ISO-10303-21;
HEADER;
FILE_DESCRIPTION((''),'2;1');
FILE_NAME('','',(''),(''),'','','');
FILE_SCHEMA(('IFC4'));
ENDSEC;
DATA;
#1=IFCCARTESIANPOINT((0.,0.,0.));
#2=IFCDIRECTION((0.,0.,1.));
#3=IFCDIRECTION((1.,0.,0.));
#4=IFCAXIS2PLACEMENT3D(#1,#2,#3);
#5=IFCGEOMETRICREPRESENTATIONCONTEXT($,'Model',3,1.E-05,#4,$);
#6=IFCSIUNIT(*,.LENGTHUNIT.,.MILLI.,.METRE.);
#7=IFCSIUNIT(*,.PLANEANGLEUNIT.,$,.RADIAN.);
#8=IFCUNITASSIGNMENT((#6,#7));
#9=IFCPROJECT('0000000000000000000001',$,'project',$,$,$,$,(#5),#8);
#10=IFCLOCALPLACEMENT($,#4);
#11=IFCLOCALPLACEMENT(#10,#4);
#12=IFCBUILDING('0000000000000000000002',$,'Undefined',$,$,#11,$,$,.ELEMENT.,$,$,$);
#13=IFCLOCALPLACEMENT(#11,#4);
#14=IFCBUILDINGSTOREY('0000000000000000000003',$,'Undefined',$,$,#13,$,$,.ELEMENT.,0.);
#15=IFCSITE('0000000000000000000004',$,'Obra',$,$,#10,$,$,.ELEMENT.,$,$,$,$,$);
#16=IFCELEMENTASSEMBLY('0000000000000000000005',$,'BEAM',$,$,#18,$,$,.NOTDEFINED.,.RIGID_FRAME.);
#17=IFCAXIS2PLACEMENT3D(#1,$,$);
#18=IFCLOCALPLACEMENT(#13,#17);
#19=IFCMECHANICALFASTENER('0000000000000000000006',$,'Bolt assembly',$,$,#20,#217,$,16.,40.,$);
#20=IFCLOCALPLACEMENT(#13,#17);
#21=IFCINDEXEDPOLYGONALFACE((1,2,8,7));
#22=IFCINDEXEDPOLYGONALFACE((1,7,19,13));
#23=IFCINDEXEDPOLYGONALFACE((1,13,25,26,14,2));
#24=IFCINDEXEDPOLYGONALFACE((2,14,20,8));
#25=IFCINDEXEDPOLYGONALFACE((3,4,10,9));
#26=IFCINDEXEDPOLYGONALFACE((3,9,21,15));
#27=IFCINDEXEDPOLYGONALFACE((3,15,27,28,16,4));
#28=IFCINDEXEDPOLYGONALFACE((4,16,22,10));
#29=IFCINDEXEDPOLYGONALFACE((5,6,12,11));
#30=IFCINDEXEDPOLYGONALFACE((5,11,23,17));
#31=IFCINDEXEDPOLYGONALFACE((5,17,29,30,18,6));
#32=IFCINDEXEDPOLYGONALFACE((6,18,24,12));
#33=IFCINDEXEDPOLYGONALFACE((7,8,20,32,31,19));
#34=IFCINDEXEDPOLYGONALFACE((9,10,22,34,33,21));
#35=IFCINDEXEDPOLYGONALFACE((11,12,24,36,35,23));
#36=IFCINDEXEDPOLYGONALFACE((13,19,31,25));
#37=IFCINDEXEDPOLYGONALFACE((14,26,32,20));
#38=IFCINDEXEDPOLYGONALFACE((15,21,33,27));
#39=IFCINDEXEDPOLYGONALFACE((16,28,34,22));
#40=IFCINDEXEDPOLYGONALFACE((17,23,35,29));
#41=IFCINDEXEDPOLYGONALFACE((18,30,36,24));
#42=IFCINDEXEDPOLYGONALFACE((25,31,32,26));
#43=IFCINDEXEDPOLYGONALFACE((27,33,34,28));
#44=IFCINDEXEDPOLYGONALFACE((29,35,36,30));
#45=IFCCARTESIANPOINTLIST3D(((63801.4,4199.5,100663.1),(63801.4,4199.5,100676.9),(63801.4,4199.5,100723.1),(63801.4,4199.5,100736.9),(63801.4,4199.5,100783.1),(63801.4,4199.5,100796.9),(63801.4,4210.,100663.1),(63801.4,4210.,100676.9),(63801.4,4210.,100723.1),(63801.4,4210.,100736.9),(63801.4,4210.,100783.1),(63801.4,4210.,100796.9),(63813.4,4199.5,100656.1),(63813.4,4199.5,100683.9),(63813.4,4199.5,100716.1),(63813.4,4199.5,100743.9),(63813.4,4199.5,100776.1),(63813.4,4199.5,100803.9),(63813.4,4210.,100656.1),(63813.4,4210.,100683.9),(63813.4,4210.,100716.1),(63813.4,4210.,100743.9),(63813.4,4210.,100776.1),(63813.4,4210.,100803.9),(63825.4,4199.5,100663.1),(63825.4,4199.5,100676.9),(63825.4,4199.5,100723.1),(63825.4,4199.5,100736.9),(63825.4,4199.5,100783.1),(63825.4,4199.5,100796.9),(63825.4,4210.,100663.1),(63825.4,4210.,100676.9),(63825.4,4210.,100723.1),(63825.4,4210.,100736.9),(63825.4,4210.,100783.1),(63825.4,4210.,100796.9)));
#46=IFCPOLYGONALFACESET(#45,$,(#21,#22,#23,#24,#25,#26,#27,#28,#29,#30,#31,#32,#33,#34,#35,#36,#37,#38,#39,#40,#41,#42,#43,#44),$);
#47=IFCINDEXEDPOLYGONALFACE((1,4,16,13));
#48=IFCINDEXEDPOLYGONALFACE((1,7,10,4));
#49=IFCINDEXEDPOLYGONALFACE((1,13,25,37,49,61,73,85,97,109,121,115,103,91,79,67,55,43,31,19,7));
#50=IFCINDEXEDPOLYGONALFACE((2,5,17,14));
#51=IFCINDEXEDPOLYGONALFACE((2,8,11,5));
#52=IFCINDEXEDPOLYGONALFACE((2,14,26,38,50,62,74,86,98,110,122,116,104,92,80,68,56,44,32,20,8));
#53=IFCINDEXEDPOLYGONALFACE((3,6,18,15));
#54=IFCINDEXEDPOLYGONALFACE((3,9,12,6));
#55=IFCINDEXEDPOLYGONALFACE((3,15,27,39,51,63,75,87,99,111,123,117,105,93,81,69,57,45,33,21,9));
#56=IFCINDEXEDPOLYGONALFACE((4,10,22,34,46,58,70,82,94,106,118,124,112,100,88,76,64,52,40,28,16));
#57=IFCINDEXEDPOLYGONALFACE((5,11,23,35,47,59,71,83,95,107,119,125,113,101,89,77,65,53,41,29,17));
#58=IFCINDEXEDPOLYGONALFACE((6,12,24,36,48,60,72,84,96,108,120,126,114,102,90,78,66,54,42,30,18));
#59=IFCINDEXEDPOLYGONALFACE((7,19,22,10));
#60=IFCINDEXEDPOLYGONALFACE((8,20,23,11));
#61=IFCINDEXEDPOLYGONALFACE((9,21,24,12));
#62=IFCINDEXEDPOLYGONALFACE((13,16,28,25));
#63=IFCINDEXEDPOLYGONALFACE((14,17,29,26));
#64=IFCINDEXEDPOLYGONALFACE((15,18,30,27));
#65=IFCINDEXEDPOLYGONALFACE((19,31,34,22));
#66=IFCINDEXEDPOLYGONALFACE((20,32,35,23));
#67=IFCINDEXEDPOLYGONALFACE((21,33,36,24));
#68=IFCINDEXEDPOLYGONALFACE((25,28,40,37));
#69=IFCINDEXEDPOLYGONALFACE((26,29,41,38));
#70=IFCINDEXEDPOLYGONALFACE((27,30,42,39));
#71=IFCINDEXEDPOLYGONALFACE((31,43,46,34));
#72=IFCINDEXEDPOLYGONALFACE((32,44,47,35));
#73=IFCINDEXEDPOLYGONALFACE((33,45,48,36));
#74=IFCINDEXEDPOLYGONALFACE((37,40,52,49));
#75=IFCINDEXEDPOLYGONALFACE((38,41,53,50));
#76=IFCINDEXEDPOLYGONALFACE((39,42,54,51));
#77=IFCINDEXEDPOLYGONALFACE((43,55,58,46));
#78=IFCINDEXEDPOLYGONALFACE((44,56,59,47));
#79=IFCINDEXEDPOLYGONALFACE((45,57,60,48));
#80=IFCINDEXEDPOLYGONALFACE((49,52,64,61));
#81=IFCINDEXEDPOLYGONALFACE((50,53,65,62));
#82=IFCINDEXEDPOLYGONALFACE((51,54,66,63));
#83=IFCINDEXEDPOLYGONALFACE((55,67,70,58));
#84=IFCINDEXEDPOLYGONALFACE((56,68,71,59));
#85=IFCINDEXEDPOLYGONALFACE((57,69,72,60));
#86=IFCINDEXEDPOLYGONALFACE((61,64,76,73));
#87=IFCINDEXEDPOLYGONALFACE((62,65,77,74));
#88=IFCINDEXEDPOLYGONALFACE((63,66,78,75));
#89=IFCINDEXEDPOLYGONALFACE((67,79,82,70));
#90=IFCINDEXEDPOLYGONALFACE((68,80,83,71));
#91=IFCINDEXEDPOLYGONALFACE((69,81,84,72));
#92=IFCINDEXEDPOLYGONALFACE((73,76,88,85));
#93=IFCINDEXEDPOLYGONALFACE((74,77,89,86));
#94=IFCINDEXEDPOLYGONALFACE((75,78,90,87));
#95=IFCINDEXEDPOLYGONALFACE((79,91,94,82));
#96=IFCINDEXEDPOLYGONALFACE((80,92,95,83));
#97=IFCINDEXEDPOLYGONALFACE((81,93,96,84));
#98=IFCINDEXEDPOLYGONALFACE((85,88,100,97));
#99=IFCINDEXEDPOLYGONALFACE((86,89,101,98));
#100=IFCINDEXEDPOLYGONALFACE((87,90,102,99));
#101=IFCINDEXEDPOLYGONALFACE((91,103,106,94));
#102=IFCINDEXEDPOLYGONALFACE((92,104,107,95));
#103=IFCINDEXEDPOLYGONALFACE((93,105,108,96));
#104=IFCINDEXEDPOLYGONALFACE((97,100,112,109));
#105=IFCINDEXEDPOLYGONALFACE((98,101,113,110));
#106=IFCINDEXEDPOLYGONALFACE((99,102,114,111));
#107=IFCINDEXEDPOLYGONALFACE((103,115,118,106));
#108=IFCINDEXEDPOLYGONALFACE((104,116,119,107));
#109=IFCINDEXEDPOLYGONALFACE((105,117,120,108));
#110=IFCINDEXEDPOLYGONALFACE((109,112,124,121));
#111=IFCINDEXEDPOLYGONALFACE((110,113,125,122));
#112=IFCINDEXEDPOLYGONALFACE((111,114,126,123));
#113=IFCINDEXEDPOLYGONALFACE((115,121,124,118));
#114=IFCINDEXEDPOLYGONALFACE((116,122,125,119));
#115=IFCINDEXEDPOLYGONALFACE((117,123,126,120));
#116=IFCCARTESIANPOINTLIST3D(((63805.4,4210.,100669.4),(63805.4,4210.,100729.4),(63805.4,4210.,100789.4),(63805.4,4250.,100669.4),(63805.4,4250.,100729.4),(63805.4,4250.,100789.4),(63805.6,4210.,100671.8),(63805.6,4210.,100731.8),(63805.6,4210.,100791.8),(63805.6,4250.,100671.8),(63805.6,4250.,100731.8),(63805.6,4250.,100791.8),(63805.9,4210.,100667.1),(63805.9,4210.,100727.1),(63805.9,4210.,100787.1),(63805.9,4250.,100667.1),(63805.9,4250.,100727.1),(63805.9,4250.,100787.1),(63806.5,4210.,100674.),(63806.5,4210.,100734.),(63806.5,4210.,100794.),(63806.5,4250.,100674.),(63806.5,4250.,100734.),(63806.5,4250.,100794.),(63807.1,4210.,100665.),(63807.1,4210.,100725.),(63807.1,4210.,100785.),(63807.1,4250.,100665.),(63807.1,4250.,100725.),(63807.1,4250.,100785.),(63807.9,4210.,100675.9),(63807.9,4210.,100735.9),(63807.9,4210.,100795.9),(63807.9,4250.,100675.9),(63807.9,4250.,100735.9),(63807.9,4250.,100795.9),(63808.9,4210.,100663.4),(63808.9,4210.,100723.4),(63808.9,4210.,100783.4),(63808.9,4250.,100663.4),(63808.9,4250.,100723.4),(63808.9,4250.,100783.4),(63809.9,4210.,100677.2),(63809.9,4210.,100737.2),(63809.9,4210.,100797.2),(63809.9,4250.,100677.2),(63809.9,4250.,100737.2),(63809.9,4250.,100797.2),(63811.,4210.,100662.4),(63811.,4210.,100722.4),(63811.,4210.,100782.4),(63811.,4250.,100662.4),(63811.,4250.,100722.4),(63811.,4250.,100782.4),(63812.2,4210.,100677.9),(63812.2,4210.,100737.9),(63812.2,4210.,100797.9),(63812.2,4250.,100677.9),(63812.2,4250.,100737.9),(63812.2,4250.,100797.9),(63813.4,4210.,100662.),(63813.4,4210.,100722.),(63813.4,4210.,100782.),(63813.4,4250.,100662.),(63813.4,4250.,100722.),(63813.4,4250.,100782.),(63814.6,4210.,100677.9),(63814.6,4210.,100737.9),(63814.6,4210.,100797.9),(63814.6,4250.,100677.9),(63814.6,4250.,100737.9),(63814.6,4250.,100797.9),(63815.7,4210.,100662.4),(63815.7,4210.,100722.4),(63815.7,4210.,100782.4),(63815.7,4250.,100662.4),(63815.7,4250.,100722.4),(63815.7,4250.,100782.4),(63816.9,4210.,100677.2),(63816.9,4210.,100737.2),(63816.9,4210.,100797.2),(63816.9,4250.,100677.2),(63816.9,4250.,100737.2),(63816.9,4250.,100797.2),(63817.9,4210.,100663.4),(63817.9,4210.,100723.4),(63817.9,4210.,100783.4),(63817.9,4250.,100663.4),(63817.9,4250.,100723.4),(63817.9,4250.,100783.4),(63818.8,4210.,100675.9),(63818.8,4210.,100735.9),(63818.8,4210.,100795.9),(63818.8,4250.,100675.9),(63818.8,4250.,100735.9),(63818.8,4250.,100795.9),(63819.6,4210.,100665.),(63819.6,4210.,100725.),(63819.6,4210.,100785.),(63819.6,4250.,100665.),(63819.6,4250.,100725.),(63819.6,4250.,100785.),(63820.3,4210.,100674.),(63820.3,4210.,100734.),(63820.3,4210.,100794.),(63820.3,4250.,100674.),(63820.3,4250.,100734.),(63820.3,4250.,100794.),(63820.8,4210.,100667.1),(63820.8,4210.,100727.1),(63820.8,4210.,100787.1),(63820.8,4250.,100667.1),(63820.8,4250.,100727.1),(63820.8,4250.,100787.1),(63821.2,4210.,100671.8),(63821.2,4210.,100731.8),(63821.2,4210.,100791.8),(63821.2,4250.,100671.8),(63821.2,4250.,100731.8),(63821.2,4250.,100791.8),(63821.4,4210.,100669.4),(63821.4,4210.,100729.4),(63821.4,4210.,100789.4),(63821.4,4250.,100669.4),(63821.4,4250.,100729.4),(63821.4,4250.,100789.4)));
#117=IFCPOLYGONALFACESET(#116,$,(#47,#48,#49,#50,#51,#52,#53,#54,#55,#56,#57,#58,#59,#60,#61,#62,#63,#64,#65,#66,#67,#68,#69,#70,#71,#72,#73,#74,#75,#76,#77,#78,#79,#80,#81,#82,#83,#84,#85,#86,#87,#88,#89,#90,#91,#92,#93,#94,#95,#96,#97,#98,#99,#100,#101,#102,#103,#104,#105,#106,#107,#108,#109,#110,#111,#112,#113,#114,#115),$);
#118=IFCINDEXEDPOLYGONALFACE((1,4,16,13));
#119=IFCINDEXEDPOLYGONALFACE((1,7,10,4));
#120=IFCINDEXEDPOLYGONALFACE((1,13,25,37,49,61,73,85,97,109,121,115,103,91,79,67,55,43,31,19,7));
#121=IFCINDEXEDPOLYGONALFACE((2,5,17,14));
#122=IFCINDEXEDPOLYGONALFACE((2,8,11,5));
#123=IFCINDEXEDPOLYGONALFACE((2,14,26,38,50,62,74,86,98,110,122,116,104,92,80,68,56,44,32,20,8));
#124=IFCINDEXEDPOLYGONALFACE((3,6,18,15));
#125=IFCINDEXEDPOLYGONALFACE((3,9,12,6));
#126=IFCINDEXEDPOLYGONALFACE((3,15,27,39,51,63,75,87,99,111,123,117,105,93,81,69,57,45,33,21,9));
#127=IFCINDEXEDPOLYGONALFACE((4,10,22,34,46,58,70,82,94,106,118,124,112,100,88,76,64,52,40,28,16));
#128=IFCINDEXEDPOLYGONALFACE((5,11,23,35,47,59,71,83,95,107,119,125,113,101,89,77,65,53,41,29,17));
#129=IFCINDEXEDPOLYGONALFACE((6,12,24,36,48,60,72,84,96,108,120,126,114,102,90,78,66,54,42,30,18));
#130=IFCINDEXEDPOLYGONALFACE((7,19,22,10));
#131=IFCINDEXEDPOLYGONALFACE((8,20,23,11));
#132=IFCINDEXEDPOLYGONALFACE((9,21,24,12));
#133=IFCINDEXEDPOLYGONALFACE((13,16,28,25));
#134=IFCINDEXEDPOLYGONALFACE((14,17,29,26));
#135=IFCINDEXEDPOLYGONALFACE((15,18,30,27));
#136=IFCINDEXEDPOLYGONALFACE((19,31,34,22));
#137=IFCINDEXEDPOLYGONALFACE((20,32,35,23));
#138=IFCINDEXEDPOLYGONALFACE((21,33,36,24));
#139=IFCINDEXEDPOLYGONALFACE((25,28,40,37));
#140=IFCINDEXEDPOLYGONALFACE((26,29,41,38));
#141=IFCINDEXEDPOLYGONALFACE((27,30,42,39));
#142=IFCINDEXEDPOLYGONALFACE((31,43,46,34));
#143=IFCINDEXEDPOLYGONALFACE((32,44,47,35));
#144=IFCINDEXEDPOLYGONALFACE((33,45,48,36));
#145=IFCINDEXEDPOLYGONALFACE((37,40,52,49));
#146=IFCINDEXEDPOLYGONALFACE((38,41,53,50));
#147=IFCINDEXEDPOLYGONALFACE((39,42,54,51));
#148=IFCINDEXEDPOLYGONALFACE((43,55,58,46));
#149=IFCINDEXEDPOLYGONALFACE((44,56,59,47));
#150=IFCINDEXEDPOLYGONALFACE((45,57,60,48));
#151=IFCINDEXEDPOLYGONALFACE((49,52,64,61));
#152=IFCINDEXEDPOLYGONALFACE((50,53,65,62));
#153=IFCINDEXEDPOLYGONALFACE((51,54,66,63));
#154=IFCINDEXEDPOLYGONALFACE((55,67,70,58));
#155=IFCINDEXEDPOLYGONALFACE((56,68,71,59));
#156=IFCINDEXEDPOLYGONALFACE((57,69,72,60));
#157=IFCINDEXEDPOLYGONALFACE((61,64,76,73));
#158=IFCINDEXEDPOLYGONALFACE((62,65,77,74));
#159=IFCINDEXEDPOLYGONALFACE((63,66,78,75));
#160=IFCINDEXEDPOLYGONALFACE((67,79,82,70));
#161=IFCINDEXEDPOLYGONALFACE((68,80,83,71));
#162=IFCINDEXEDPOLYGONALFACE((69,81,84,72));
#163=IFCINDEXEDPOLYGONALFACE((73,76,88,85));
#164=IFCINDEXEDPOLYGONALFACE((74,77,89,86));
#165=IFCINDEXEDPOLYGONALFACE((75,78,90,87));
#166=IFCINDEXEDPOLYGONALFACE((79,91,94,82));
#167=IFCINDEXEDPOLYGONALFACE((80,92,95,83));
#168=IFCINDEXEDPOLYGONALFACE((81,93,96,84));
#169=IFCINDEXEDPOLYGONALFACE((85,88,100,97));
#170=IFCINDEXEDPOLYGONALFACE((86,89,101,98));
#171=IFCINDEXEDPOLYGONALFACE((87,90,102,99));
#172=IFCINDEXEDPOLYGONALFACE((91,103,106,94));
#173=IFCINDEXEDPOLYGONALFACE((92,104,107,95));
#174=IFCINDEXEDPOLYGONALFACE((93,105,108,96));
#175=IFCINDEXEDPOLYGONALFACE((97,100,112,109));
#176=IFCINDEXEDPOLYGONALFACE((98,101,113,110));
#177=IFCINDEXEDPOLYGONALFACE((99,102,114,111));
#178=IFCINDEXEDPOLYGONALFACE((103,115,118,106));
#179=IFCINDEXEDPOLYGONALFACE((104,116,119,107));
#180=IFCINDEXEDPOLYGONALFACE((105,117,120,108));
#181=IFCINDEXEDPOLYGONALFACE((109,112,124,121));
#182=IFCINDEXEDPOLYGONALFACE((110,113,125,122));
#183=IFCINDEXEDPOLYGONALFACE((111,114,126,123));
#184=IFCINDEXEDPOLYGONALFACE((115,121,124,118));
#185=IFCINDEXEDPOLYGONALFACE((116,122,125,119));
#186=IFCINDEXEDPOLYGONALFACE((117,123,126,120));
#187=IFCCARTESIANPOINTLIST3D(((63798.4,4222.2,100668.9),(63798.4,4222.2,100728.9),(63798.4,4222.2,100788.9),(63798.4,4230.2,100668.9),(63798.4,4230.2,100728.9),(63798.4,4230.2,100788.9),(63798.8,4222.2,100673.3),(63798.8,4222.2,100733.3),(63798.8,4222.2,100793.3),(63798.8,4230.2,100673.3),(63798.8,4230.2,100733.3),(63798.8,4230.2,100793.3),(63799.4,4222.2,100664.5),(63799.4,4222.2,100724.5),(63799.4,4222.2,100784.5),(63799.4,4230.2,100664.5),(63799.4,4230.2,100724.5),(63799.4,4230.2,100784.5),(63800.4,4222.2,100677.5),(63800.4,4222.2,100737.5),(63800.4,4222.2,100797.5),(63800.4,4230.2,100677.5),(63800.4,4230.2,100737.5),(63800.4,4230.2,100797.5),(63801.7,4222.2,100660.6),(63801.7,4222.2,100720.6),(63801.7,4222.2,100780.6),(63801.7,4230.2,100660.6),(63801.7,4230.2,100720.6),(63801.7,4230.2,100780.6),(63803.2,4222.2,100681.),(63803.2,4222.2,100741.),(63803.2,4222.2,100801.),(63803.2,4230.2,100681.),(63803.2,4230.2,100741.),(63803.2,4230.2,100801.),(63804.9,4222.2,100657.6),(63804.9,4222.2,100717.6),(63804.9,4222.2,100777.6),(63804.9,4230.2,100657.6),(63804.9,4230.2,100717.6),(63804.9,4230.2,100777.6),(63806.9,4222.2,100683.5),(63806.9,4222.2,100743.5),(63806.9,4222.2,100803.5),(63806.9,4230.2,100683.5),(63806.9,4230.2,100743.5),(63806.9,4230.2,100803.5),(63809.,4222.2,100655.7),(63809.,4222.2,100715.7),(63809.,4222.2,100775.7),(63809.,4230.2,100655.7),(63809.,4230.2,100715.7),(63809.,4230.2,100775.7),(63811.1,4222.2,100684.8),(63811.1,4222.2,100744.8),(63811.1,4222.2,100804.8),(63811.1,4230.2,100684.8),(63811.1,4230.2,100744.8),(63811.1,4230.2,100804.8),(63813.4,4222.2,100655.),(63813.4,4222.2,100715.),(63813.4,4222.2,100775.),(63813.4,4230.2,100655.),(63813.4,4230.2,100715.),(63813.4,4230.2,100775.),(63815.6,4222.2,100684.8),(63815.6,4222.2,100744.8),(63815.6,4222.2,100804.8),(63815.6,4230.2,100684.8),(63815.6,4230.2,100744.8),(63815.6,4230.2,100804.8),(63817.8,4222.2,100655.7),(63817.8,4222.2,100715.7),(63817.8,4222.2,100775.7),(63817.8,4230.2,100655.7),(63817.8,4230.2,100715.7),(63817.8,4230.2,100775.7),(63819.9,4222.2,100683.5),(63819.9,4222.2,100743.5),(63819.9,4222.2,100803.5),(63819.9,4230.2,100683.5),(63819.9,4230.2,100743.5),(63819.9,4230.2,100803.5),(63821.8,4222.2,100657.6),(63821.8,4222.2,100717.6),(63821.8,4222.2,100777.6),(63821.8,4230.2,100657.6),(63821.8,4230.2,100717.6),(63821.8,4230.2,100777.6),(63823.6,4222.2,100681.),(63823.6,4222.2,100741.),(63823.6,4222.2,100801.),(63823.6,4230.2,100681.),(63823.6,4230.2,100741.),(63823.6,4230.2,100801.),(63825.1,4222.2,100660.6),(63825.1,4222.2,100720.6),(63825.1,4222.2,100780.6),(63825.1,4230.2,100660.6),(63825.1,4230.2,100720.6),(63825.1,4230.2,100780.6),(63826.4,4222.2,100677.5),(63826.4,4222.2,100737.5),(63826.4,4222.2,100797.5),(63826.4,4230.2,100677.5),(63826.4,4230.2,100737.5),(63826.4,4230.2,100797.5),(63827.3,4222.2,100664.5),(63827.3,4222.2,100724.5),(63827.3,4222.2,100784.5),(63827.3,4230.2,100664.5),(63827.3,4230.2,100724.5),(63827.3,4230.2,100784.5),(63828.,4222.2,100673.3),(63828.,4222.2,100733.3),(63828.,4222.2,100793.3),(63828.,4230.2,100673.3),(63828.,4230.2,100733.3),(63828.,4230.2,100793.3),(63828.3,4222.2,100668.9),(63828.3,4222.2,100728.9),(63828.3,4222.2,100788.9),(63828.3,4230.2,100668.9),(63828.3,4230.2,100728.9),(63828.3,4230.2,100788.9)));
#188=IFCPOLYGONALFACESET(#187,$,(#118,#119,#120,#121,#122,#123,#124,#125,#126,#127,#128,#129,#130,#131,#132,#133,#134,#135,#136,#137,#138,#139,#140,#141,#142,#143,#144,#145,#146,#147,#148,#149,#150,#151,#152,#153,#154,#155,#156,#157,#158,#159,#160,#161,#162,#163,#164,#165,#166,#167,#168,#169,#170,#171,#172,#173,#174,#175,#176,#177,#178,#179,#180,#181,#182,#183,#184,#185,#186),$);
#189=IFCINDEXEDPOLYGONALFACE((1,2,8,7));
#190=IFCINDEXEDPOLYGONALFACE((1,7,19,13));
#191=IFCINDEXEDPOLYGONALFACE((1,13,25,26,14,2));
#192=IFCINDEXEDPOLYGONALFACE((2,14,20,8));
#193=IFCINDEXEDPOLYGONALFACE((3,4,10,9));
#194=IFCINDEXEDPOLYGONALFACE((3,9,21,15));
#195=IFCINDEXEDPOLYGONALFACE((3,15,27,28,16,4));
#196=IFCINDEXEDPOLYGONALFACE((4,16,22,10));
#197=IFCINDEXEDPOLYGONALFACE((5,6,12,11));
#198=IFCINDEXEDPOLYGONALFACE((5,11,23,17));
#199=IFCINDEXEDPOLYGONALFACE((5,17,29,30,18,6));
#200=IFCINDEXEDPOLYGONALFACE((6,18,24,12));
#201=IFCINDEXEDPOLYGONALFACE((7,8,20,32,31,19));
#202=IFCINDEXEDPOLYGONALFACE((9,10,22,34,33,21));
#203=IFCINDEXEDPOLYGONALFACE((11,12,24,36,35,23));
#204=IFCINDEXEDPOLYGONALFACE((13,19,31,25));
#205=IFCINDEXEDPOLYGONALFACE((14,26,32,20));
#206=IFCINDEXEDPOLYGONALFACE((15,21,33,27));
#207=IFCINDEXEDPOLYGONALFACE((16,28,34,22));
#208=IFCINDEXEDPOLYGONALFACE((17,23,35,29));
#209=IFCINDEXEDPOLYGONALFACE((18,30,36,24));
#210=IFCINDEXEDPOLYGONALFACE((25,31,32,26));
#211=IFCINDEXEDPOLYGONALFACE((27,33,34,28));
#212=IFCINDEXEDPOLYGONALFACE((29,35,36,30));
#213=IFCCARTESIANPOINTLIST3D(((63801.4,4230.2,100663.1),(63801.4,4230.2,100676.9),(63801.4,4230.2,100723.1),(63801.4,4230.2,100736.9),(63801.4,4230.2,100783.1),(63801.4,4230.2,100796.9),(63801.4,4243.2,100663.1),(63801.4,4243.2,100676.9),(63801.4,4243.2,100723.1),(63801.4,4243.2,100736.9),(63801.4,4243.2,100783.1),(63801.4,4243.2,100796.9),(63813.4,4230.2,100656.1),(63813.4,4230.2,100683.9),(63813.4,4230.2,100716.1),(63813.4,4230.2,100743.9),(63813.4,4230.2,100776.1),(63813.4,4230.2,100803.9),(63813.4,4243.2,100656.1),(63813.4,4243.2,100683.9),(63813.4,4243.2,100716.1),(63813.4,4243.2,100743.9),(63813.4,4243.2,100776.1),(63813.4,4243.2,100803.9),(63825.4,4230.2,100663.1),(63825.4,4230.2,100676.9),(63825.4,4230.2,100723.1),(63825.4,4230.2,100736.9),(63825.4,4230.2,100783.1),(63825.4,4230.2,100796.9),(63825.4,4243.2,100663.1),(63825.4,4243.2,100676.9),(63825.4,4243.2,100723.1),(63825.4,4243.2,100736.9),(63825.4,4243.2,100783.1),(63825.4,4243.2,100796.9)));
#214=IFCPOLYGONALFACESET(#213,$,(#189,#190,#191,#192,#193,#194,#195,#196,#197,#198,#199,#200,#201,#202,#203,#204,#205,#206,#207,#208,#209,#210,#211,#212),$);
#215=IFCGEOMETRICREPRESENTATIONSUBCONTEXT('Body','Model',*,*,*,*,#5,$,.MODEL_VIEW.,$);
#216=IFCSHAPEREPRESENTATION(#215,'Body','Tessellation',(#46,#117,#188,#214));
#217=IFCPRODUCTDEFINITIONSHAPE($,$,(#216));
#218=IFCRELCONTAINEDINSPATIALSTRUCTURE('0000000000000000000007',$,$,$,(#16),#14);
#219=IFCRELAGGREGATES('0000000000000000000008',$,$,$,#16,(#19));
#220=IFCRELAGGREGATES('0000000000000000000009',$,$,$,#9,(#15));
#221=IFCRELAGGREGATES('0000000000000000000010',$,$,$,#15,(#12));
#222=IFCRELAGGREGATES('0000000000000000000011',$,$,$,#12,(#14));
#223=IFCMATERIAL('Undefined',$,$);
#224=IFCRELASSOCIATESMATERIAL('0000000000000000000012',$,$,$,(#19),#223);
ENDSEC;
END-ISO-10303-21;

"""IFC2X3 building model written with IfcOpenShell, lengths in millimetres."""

from ifc_helpers import new_model, si_unit, frame, origin_with_axes, origin_2d_with_axis, place, context, subcontext, project, spatial, polyline, circle, outline, extrude, source, transform, mapped, material, element, aggregate, save


model = new_model("IFC2X3")

# Units and contexts
model_context = context("Model", 3, precision=1e-05, world=origin_with_axes())
body_context = subcontext(model_context, "Body", "Model", "MODEL_VIEW")
ifc_project = project(units=[si_unit("LENGTHUNIT", "METRE", prefix="MILLI"), si_unit("PLANEANGLEUNIT", "RADIAN")], contexts=[model_context])

# Site, building, storey
site_placement = place(None, origin_with_axes())
site = spatial("IfcSite", under=ifc_project, at=site_placement, Name="Obra", CompositionType="ELEMENT")
building_placement = place(site_placement, origin_with_axes())
building = spatial("IfcBuilding", under=site, at=building_placement, Name="Undefined", CompositionType="ELEMENT")
storey_placement = place(building_placement, origin_with_axes())
storey = spatial("IfcBuildingStorey", under=building, at=storey_placement, Name="Undefined", CompositionType="ELEMENT", Elevation=0.0)

# Shared definitions
ifc_material_1 = material(Name="Undefined")

# Shared definitions
shared_shape_1 = source(origin_with_axes(), body_context, "Body", "SweptSolid", [
    extrude(outline(polyline([(13.9, 0.0), (6.9, 12.0), (-6.9, 12.0), (-13.9, 0.0), (-6.9, -12.0), (6.9, -12.0), (13.9, 0.0)])), frame((0.0, -19.7, 0.0), z_axis=(0.0, 1.0, 0.0), x_axis=(1.0, 0.0, 0.0)), (0.0, 0.0, 1.0), 10.6),
    extrude(circle(Radius=8.0, at=origin_2d_with_axis()), frame((0.0, -9.1, 0.0), z_axis=(0.0, 1.0, 0.0), x_axis=(1.0, 0.0, 0.0)), (0.0, 0.0, 1.0), 40.0),
    extrude(circle(Radius=15.0, at=origin_2d_with_axis()), frame((0.0, 3.1, 0.0), z_axis=(0.0, 1.0, 0.0), x_axis=(1.0, 0.0, 0.0)), (0.0, 0.0, 1.0), 8.0),
    extrude(outline(polyline([(13.9, 0.0), (6.9, 12.0), (-6.9, 12.0), (-13.9, 0.0), (-6.9, -12.0), (6.9, -12.0), (13.9, 0.0)])), frame((0.0, 11.1, 0.0), z_axis=(0.0, 1.0, 0.0), x_axis=(1.0, 0.0, 0.0)), (0.0, 0.0, 1.0), 13.0),
])

# Element assembly
assembly_1_placement = place(storey_placement, origin_with_axes())
assembly_1 = element("IfcElementAssembly", 1, at=assembly_1_placement, inside=storey, Name="BEAM", AssemblyPlace="NOTDEFINED", PredefinedType="RIGID_FRAME")

# Mechanical fastener
mechanical_fastener_1_placement = place(assembly_1_placement, frame((63763.4, 4219.1, 100850.0), z_axis=(1.0, 0.0, 0.0), x_axis=(0.0, 0.0, -1.0)))
mechanical_fastener_1 = element("IfcMechanicalFastener", 2, at=mechanical_fastener_1_placement, material=ifc_material_1, Name="Bolt assembly", NominalDiameter=16.0, NominalLength=40.0, context=body_context, shape_type="MappedRepresentation", body=[
    mapped(shared_shape_1, transform((60.0, 0.0, 50.0))),
    mapped(shared_shape_1, transform((120.0, 0.0, 50.0))),
    mapped(shared_shape_1, transform((180.0, 0.0, 50.0))),
])
aggregate(assembly_1, [mechanical_fastener_1])

save(model, "model.ifc")
